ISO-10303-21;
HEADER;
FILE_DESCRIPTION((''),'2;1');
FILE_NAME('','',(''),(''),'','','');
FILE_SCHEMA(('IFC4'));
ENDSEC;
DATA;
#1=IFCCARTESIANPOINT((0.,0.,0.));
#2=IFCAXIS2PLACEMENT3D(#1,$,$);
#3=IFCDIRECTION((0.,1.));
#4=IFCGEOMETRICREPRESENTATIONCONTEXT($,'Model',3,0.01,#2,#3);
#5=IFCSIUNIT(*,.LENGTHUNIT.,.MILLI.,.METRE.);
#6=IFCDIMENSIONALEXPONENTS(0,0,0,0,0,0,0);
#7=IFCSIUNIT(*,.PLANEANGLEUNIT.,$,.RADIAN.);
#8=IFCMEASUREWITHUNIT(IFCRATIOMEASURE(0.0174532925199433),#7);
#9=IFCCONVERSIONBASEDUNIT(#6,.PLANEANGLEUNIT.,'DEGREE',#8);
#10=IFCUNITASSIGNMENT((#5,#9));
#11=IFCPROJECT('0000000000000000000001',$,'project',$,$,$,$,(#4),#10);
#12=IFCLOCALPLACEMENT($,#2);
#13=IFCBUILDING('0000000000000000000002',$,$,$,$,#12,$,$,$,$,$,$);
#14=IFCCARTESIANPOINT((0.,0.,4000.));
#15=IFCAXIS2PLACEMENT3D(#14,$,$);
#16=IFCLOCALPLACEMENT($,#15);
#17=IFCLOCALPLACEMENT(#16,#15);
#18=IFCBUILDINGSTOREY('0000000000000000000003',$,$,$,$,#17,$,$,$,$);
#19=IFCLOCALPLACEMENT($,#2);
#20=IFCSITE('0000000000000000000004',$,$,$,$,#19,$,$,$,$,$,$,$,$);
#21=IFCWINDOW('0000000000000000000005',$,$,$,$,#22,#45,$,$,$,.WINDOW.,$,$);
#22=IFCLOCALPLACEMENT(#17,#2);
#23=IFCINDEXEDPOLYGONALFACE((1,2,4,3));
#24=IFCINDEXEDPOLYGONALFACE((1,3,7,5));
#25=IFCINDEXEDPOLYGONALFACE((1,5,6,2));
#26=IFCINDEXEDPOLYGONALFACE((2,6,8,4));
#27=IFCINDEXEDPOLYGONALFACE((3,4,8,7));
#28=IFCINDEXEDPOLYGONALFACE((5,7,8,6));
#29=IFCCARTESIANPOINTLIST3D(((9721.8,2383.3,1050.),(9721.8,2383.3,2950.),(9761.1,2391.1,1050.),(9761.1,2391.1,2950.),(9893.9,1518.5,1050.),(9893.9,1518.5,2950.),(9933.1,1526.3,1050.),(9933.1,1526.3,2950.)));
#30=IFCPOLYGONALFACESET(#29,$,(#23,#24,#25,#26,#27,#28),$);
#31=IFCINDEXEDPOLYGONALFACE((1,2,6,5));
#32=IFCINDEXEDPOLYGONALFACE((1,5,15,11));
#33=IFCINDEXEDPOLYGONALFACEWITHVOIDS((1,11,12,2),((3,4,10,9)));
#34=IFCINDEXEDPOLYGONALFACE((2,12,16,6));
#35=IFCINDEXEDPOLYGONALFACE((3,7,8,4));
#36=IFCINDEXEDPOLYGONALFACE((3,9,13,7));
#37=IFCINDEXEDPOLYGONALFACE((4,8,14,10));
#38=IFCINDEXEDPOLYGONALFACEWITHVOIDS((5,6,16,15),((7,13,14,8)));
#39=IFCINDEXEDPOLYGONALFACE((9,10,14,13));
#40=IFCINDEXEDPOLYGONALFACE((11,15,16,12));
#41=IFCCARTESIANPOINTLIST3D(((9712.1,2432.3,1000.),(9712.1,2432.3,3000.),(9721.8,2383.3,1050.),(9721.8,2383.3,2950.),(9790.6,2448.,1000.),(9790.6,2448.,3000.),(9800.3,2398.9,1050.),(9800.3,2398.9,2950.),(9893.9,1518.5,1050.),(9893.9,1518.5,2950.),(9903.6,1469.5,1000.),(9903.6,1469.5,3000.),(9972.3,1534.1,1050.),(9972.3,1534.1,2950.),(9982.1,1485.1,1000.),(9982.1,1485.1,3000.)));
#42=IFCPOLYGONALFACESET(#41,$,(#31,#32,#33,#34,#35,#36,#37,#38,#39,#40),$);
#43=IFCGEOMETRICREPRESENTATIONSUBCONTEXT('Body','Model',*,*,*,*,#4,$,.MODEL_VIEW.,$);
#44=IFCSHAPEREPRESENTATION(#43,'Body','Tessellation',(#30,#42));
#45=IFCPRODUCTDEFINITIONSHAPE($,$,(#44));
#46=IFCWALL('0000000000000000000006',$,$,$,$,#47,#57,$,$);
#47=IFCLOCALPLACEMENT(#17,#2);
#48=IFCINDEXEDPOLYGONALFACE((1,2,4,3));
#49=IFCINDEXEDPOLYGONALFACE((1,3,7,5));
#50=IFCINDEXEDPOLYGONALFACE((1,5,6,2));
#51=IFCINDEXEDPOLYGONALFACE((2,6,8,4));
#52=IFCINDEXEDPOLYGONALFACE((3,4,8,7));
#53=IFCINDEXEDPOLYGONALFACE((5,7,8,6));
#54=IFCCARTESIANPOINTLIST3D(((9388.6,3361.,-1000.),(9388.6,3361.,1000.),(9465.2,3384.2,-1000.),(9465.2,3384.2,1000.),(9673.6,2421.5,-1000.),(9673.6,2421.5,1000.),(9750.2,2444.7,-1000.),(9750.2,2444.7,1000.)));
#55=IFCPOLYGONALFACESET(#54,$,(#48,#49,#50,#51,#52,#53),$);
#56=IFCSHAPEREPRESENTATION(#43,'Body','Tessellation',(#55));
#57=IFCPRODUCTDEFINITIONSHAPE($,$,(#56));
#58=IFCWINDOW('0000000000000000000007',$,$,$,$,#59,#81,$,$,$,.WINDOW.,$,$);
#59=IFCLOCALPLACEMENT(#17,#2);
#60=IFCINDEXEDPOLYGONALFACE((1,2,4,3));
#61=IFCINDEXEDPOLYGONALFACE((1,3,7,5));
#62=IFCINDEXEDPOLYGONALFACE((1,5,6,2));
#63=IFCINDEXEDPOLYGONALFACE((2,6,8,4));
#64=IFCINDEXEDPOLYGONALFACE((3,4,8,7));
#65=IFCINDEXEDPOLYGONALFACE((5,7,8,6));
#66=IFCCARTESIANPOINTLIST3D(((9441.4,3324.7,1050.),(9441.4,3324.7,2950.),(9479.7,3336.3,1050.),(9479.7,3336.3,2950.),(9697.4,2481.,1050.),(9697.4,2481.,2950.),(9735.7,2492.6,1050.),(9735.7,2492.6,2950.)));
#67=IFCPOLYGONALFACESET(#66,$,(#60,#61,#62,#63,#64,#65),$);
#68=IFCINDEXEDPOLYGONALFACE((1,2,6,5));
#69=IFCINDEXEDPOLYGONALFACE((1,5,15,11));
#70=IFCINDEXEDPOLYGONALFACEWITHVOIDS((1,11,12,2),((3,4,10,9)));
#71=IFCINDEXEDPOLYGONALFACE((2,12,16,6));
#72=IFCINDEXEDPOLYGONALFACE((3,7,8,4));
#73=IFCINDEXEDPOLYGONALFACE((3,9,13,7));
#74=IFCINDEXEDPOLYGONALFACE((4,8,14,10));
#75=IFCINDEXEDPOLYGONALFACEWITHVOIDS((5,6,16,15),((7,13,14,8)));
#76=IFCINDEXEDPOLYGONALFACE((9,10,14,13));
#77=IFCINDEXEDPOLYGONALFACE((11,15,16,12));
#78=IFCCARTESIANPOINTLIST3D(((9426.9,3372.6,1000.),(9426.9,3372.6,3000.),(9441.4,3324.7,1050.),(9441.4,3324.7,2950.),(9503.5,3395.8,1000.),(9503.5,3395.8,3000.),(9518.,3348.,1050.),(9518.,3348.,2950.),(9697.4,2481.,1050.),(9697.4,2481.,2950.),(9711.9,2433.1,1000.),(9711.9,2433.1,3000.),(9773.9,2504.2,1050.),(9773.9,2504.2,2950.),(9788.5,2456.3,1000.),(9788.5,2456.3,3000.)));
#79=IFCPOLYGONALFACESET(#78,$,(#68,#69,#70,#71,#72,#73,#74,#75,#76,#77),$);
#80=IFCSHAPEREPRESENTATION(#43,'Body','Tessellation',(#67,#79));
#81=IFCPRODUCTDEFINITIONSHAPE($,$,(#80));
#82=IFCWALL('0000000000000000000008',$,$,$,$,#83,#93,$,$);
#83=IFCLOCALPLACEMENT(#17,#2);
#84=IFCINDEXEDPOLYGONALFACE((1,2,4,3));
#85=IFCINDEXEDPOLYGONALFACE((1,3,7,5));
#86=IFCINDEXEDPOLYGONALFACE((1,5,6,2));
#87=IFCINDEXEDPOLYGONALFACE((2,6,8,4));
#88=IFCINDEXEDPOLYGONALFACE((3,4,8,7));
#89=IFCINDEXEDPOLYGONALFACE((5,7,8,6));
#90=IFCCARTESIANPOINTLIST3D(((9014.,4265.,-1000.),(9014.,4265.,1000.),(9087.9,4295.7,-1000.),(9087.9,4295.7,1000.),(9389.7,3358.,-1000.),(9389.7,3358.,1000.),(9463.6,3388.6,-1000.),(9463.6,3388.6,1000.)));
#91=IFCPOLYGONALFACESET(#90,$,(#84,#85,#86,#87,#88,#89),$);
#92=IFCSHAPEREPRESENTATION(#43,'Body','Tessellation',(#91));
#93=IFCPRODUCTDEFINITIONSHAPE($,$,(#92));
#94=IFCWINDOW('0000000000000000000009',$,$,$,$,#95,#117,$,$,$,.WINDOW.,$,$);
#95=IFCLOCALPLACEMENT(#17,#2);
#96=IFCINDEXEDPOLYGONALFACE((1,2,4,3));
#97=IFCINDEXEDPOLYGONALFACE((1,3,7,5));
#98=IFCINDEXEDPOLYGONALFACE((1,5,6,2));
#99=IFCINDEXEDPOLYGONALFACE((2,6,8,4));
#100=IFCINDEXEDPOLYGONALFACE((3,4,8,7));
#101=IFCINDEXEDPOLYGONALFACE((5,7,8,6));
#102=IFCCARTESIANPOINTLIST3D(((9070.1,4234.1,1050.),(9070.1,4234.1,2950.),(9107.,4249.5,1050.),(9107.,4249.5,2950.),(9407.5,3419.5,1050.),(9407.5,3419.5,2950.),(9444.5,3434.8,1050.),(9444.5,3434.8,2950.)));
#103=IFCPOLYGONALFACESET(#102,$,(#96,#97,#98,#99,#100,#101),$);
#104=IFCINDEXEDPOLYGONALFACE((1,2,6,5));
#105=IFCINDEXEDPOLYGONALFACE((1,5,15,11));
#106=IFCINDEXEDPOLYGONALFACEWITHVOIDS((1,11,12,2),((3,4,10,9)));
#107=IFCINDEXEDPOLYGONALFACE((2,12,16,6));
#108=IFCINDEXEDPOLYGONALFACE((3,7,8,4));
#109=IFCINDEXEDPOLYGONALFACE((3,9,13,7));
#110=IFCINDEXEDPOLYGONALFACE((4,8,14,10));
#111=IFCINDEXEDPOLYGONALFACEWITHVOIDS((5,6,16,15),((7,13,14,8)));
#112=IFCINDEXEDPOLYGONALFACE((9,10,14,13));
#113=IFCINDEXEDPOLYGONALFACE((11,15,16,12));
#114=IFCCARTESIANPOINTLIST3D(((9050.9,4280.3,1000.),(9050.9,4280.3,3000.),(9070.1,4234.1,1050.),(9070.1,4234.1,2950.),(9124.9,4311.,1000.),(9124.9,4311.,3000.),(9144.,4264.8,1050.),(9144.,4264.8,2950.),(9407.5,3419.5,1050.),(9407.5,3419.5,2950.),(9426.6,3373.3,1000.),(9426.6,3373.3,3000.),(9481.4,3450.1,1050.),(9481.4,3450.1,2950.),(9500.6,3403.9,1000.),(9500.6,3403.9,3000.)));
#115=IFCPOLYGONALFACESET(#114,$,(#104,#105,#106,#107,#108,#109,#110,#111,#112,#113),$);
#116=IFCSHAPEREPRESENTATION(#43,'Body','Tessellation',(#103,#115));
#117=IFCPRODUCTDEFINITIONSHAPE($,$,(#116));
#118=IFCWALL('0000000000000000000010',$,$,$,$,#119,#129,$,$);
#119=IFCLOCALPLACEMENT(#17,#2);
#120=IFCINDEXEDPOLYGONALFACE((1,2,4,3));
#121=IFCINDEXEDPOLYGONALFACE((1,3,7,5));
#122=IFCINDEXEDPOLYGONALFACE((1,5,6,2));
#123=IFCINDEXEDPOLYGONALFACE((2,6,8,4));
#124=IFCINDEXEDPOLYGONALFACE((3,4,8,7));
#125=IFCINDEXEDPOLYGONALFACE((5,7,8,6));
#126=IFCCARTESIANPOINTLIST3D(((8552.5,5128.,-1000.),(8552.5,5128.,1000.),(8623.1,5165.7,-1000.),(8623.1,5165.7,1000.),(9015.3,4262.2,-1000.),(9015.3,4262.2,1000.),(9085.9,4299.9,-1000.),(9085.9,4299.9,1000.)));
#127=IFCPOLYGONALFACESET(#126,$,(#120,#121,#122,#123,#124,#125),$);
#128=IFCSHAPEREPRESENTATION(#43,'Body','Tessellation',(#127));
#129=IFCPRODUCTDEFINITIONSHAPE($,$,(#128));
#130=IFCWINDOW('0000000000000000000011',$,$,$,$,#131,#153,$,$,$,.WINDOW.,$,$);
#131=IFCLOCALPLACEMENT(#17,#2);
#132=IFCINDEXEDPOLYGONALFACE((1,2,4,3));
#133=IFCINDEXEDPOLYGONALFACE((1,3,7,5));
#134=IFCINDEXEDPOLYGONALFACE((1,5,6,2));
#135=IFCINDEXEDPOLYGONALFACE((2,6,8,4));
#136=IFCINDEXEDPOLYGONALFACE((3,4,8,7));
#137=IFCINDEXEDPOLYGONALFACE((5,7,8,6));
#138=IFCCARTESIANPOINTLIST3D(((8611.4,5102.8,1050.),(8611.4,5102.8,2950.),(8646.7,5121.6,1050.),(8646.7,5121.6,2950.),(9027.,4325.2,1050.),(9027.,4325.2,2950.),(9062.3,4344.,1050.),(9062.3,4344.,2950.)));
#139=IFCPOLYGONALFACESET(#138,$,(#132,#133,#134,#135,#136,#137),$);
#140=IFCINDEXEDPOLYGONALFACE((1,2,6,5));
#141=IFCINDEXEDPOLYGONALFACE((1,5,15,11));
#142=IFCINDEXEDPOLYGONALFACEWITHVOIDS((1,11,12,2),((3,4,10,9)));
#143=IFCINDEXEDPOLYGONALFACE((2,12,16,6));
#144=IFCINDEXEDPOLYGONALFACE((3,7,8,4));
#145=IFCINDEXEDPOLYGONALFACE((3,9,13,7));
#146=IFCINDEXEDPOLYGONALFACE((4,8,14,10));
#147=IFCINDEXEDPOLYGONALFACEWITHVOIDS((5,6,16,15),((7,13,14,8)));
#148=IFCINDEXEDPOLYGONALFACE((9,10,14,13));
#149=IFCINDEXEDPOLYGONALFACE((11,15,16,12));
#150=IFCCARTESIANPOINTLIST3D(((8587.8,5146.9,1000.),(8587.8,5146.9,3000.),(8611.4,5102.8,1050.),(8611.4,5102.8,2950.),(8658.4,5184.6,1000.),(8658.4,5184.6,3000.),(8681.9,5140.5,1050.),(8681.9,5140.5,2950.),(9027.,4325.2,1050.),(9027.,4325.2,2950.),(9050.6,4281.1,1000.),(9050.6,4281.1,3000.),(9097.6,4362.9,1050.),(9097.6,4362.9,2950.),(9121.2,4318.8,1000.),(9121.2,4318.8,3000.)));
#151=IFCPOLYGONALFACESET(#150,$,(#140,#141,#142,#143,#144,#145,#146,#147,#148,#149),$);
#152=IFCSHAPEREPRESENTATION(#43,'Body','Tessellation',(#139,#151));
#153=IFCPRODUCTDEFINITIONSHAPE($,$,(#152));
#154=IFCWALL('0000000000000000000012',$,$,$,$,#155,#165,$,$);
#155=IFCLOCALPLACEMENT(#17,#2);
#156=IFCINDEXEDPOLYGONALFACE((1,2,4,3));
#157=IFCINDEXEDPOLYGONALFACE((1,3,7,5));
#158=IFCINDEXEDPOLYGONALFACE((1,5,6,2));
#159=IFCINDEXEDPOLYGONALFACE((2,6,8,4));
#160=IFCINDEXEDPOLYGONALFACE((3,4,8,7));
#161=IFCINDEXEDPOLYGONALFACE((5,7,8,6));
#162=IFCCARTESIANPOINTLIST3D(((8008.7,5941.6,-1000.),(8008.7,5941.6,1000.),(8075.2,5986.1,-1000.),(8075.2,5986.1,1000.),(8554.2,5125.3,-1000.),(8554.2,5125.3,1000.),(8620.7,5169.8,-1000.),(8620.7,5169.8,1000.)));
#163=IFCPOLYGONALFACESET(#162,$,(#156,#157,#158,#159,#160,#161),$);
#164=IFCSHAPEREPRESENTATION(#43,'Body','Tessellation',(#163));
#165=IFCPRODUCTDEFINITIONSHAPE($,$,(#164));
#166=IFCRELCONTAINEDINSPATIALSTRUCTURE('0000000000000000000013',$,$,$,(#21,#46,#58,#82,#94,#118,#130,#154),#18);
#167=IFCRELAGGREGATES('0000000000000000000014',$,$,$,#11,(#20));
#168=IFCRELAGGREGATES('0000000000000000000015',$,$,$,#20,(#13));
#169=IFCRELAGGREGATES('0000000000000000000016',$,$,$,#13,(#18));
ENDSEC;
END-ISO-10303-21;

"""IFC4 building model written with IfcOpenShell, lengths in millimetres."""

from ifc_helpers import new_model, entity, si_unit, converted_unit, direction, frame, origin, origin_2d, place, context, subcontext, project, spatial, rectangle, extrude, element, save


model = new_model("IFC4")

# Units and contexts
model_context = context("Model", 3, precision=0.01, world=origin(), true_north=direction((0.0, 1.0)))
body_context = subcontext(model_context, "Body", "Model", "MODEL_VIEW")
ifc_project = project(units=[si_unit("LENGTHUNIT", "METRE", prefix="MILLI"), converted_unit("PLANEANGLEUNIT", "DEGREE", entity("IfcRatioMeasure", 0.0174532925199433), si_unit("PLANEANGLEUNIT", "RADIAN"), dimensions=[0, 0, 0, 0, 0, 0, 0])], contexts=[model_context])

# Site, building, storey
site_placement = place(None, origin())
site = spatial("IfcSite", under=ifc_project, at=site_placement)
building_placement = place(None, origin())
building = spatial("IfcBuilding", under=site, at=building_placement)
placement = place(None, frame((0.0, 0.0, 4000.0)))
storey_placement = place(placement, frame((0.0, 0.0, 4000.0)))
storey = spatial("IfcBuildingStorey", under=building, at=storey_placement)

# Shared definitions
cartesian_point_1 = entity("IfcCartesianPoint", [-440.9, -950.0])
shared_polyline = entity("IfcPolyline", [cartesian_point_1, entity("IfcCartesianPoint", [-440.9, 950.0]), entity("IfcCartesianPoint", [-440.9, 950.0]), entity("IfcCartesianPoint", [440.9, 950.0]), entity("IfcCartesianPoint", [440.9, 950.0]), entity("IfcCartesianPoint", [440.9, -950.0]), entity("IfcCartesianPoint", [440.9, -950.0]), entity("IfcCartesianPoint", [-440.9, -950.0]), cartesian_point_1])

# Window
window_1_placement = place(storey_placement, frame((9807.9, 1950.9, 2000.0), z_axis=(0.0, 0.0, 1.0), x_axis=(-1950.903274, 9807.852793, 0.0)))
cartesian_point_2 = entity("IfcCartesianPoint", [-490.9, -1000.0])
element("IfcWindow", 1, at=window_1_placement, inside=storey, PredefinedType="WINDOW", context=body_context, shape_type="SweptSolid", body=[
    entity("IfcExtrudedAreaSolid", entity("IfcArbitraryClosedProfileDef", "AREA", None, shared_polyline), entity("IfcAxis2Placement3D", entity("IfcCartesianPoint", [0.0, 0.0, 0.0]), entity("IfcDirection", [0.0, -1.0, 0.0]), entity("IfcDirection", [1.0, 0.0, 0.0])), entity("IfcDirection", [0.0, 0.0, 1.0]), 40.0),
    entity("IfcExtrudedAreaSolid", entity("IfcArbitraryProfileDefWithVoids", "AREA", None, entity("IfcPolyline", [cartesian_point_2, entity("IfcCartesianPoint", [-490.9, 1000.0]), entity("IfcCartesianPoint", [-490.9, 1000.0]), entity("IfcCartesianPoint", [490.9, 1000.0]), entity("IfcCartesianPoint", [490.9, 1000.0]), entity("IfcCartesianPoint", [490.9, -1000.0]), entity("IfcCartesianPoint", [490.9, -1000.0]), entity("IfcCartesianPoint", [-490.9, -1000.0]), cartesian_point_2]), [shared_polyline]), entity("IfcAxis2Placement3D", entity("IfcCartesianPoint", [0.0, 0.0, 0.0]), entity("IfcDirection", [0.0, -1.0, 0.0]), entity("IfcDirection", [1.0, 0.0, 0.0])), entity("IfcDirection", [0.0, 0.0, 1.0]), 80.0),
])

# Wall
wall_1_placement = place(storey_placement, frame((9569.4, 2902.8, -1000.0), z_axis=(0.0, 0.0, 1.0), x_axis=(-2902.84678, 9569.403355, 0.0)))
element("IfcWall", 2, at=wall_1_placement, inside=storey, context=body_context, shape_type="SweptSolid", body=[
    extrude(rectangle(XDim=981.7, YDim=80.0, at=origin_2d()), origin(), (0.0, 0.0, 1.0), 2000.0),
])

# Window
window_2_placement = place(storey_placement, frame((9569.4, 2902.8, 2000.0), z_axis=(0.0, 0.0, 1.0), x_axis=(-2902.84678, 9569.403355, 0.0)))
cartesian_point_3 = entity("IfcCartesianPoint", [-490.9, -1000.0])
element("IfcWindow", 3, at=window_2_placement, inside=storey, PredefinedType="WINDOW", context=body_context, shape_type="SweptSolid", body=[
    entity("IfcExtrudedAreaSolid", entity("IfcArbitraryClosedProfileDef", "AREA", None, shared_polyline), entity("IfcAxis2Placement3D", entity("IfcCartesianPoint", [0.0, 0.0, 0.0]), entity("IfcDirection", [0.0, -1.0, 0.0]), entity("IfcDirection", [1.0, 0.0, 0.0])), entity("IfcDirection", [0.0, 0.0, 1.0]), 40.0),
    entity("IfcExtrudedAreaSolid", entity("IfcArbitraryProfileDefWithVoids", "AREA", None, entity("IfcPolyline", [cartesian_point_3, entity("IfcCartesianPoint", [-490.9, 1000.0]), entity("IfcCartesianPoint", [-490.9, 1000.0]), entity("IfcCartesianPoint", [490.9, 1000.0]), entity("IfcCartesianPoint", [490.9, 1000.0]), entity("IfcCartesianPoint", [490.9, -1000.0]), entity("IfcCartesianPoint", [490.9, -1000.0]), entity("IfcCartesianPoint", [-490.9, -1000.0]), cartesian_point_3]), [shared_polyline]), entity("IfcAxis2Placement3D", entity("IfcCartesianPoint", [0.0, 0.0, 0.0]), entity("IfcDirection", [0.0, -1.0, 0.0]), entity("IfcDirection", [1.0, 0.0, 0.0])), entity("IfcDirection", [0.0, 0.0, 1.0]), 80.0),
])

# Wall
wall_2_placement = place(storey_placement, frame((9238.8, 3826.8, -1000.0), z_axis=(0.0, 0.0, 1.0), x_axis=(-3826.834425, 9238.795283, 0.0)))
element("IfcWall", 4, at=wall_2_placement, inside=storey, context=body_context, shape_type="SweptSolid", body=[
    extrude(rectangle(XDim=981.7, YDim=80.0, at=origin_2d()), origin(), (0.0, 0.0, 1.0), 2000.0),
])

# Window
window_3_placement = place(storey_placement, frame((9238.8, 3826.8, 2000.0), z_axis=(0.0, 0.0, 1.0), x_axis=(-3826.834425, 9238.795283, 0.0)))
cartesian_point_4 = entity("IfcCartesianPoint", [-490.9, -1000.0])
element("IfcWindow", 5, at=window_3_placement, inside=storey, PredefinedType="WINDOW", context=body_context, shape_type="SweptSolid", body=[
    entity("IfcExtrudedAreaSolid", entity("IfcArbitraryClosedProfileDef", "AREA", None, shared_polyline), entity("IfcAxis2Placement3D", entity("IfcCartesianPoint", [0.0, 0.0, 0.0]), entity("IfcDirection", [0.0, -1.0, 0.0]), entity("IfcDirection", [1.0, 0.0, 0.0])), entity("IfcDirection", [0.0, 0.0, 1.0]), 40.0),
    entity("IfcExtrudedAreaSolid", entity("IfcArbitraryProfileDefWithVoids", "AREA", None, entity("IfcPolyline", [cartesian_point_4, entity("IfcCartesianPoint", [-490.9, 1000.0]), entity("IfcCartesianPoint", [-490.9, 1000.0]), entity("IfcCartesianPoint", [490.9, 1000.0]), entity("IfcCartesianPoint", [490.9, 1000.0]), entity("IfcCartesianPoint", [490.9, -1000.0]), entity("IfcCartesianPoint", [490.9, -1000.0]), entity("IfcCartesianPoint", [-490.9, -1000.0]), cartesian_point_4]), [shared_polyline]), entity("IfcAxis2Placement3D", entity("IfcCartesianPoint", [0.0, 0.0, 0.0]), entity("IfcDirection", [0.0, -1.0, 0.0]), entity("IfcDirection", [1.0, 0.0, 0.0])), entity("IfcDirection", [0.0, 0.0, 1.0]), 80.0),
])

# Wall
wall_3_placement = place(storey_placement, frame((8819.2, 4714.0, -1000.0), z_axis=(0.0, 0.0, 1.0), x_axis=(-4713.967292, 8819.212684, 0.0)))
element("IfcWall", 6, at=wall_3_placement, inside=storey, context=body_context, shape_type="SweptSolid", body=[
    extrude(rectangle(XDim=981.7, YDim=80.0, at=origin_2d()), origin(), (0.0, 0.0, 1.0), 2000.0),
])

# Window
window_4_placement = place(storey_placement, frame((8819.2, 4714.0, 2000.0), z_axis=(0.0, 0.0, 1.0), x_axis=(-4713.967292, 8819.212684, 0.0)))
cartesian_point_5 = entity("IfcCartesianPoint", [-490.9, -1000.0])
element("IfcWindow", 7, at=window_4_placement, inside=storey, PredefinedType="WINDOW", context=body_context, shape_type="SweptSolid", body=[
    entity("IfcExtrudedAreaSolid", entity("IfcArbitraryClosedProfileDef", "AREA", None, shared_polyline), entity("IfcAxis2Placement3D", entity("IfcCartesianPoint", [0.0, 0.0, 0.0]), entity("IfcDirection", [0.0, -1.0, 0.0]), entity("IfcDirection", [1.0, 0.0, 0.0])), entity("IfcDirection", [0.0, 0.0, 1.0]), 40.0),
    entity("IfcExtrudedAreaSolid", entity("IfcArbitraryProfileDefWithVoids", "AREA", None, entity("IfcPolyline", [cartesian_point_5, entity("IfcCartesianPoint", [-490.9, 1000.0]), entity("IfcCartesianPoint", [-490.9, 1000.0]), entity("IfcCartesianPoint", [490.9, 1000.0]), entity("IfcCartesianPoint", [490.9, 1000.0]), entity("IfcCartesianPoint", [490.9, -1000.0]), entity("IfcCartesianPoint", [490.9, -1000.0]), entity("IfcCartesianPoint", [-490.9, -1000.0]), cartesian_point_5]), [shared_polyline]), entity("IfcAxis2Placement3D", entity("IfcCartesianPoint", [0.0, 0.0, 0.0]), entity("IfcDirection", [0.0, -1.0, 0.0]), entity("IfcDirection", [1.0, 0.0, 0.0])), entity("IfcDirection", [0.0, 0.0, 1.0]), 80.0),
])

# Wall
wall_4_placement = place(storey_placement, frame((8314.7, 5555.7, -1000.0), z_axis=(0.0, 0.0, 1.0), x_axis=(-5555.702343, 8314.696115, 0.0)))
element("IfcWall", 8, at=wall_4_placement, inside=storey, context=body_context, shape_type="SweptSolid", body=[
    extrude(rectangle(XDim=981.7, YDim=80.0, at=origin_2d()), origin(), (0.0, 0.0, 1.0), 2000.0),
])

save(model, "model.ifc")
